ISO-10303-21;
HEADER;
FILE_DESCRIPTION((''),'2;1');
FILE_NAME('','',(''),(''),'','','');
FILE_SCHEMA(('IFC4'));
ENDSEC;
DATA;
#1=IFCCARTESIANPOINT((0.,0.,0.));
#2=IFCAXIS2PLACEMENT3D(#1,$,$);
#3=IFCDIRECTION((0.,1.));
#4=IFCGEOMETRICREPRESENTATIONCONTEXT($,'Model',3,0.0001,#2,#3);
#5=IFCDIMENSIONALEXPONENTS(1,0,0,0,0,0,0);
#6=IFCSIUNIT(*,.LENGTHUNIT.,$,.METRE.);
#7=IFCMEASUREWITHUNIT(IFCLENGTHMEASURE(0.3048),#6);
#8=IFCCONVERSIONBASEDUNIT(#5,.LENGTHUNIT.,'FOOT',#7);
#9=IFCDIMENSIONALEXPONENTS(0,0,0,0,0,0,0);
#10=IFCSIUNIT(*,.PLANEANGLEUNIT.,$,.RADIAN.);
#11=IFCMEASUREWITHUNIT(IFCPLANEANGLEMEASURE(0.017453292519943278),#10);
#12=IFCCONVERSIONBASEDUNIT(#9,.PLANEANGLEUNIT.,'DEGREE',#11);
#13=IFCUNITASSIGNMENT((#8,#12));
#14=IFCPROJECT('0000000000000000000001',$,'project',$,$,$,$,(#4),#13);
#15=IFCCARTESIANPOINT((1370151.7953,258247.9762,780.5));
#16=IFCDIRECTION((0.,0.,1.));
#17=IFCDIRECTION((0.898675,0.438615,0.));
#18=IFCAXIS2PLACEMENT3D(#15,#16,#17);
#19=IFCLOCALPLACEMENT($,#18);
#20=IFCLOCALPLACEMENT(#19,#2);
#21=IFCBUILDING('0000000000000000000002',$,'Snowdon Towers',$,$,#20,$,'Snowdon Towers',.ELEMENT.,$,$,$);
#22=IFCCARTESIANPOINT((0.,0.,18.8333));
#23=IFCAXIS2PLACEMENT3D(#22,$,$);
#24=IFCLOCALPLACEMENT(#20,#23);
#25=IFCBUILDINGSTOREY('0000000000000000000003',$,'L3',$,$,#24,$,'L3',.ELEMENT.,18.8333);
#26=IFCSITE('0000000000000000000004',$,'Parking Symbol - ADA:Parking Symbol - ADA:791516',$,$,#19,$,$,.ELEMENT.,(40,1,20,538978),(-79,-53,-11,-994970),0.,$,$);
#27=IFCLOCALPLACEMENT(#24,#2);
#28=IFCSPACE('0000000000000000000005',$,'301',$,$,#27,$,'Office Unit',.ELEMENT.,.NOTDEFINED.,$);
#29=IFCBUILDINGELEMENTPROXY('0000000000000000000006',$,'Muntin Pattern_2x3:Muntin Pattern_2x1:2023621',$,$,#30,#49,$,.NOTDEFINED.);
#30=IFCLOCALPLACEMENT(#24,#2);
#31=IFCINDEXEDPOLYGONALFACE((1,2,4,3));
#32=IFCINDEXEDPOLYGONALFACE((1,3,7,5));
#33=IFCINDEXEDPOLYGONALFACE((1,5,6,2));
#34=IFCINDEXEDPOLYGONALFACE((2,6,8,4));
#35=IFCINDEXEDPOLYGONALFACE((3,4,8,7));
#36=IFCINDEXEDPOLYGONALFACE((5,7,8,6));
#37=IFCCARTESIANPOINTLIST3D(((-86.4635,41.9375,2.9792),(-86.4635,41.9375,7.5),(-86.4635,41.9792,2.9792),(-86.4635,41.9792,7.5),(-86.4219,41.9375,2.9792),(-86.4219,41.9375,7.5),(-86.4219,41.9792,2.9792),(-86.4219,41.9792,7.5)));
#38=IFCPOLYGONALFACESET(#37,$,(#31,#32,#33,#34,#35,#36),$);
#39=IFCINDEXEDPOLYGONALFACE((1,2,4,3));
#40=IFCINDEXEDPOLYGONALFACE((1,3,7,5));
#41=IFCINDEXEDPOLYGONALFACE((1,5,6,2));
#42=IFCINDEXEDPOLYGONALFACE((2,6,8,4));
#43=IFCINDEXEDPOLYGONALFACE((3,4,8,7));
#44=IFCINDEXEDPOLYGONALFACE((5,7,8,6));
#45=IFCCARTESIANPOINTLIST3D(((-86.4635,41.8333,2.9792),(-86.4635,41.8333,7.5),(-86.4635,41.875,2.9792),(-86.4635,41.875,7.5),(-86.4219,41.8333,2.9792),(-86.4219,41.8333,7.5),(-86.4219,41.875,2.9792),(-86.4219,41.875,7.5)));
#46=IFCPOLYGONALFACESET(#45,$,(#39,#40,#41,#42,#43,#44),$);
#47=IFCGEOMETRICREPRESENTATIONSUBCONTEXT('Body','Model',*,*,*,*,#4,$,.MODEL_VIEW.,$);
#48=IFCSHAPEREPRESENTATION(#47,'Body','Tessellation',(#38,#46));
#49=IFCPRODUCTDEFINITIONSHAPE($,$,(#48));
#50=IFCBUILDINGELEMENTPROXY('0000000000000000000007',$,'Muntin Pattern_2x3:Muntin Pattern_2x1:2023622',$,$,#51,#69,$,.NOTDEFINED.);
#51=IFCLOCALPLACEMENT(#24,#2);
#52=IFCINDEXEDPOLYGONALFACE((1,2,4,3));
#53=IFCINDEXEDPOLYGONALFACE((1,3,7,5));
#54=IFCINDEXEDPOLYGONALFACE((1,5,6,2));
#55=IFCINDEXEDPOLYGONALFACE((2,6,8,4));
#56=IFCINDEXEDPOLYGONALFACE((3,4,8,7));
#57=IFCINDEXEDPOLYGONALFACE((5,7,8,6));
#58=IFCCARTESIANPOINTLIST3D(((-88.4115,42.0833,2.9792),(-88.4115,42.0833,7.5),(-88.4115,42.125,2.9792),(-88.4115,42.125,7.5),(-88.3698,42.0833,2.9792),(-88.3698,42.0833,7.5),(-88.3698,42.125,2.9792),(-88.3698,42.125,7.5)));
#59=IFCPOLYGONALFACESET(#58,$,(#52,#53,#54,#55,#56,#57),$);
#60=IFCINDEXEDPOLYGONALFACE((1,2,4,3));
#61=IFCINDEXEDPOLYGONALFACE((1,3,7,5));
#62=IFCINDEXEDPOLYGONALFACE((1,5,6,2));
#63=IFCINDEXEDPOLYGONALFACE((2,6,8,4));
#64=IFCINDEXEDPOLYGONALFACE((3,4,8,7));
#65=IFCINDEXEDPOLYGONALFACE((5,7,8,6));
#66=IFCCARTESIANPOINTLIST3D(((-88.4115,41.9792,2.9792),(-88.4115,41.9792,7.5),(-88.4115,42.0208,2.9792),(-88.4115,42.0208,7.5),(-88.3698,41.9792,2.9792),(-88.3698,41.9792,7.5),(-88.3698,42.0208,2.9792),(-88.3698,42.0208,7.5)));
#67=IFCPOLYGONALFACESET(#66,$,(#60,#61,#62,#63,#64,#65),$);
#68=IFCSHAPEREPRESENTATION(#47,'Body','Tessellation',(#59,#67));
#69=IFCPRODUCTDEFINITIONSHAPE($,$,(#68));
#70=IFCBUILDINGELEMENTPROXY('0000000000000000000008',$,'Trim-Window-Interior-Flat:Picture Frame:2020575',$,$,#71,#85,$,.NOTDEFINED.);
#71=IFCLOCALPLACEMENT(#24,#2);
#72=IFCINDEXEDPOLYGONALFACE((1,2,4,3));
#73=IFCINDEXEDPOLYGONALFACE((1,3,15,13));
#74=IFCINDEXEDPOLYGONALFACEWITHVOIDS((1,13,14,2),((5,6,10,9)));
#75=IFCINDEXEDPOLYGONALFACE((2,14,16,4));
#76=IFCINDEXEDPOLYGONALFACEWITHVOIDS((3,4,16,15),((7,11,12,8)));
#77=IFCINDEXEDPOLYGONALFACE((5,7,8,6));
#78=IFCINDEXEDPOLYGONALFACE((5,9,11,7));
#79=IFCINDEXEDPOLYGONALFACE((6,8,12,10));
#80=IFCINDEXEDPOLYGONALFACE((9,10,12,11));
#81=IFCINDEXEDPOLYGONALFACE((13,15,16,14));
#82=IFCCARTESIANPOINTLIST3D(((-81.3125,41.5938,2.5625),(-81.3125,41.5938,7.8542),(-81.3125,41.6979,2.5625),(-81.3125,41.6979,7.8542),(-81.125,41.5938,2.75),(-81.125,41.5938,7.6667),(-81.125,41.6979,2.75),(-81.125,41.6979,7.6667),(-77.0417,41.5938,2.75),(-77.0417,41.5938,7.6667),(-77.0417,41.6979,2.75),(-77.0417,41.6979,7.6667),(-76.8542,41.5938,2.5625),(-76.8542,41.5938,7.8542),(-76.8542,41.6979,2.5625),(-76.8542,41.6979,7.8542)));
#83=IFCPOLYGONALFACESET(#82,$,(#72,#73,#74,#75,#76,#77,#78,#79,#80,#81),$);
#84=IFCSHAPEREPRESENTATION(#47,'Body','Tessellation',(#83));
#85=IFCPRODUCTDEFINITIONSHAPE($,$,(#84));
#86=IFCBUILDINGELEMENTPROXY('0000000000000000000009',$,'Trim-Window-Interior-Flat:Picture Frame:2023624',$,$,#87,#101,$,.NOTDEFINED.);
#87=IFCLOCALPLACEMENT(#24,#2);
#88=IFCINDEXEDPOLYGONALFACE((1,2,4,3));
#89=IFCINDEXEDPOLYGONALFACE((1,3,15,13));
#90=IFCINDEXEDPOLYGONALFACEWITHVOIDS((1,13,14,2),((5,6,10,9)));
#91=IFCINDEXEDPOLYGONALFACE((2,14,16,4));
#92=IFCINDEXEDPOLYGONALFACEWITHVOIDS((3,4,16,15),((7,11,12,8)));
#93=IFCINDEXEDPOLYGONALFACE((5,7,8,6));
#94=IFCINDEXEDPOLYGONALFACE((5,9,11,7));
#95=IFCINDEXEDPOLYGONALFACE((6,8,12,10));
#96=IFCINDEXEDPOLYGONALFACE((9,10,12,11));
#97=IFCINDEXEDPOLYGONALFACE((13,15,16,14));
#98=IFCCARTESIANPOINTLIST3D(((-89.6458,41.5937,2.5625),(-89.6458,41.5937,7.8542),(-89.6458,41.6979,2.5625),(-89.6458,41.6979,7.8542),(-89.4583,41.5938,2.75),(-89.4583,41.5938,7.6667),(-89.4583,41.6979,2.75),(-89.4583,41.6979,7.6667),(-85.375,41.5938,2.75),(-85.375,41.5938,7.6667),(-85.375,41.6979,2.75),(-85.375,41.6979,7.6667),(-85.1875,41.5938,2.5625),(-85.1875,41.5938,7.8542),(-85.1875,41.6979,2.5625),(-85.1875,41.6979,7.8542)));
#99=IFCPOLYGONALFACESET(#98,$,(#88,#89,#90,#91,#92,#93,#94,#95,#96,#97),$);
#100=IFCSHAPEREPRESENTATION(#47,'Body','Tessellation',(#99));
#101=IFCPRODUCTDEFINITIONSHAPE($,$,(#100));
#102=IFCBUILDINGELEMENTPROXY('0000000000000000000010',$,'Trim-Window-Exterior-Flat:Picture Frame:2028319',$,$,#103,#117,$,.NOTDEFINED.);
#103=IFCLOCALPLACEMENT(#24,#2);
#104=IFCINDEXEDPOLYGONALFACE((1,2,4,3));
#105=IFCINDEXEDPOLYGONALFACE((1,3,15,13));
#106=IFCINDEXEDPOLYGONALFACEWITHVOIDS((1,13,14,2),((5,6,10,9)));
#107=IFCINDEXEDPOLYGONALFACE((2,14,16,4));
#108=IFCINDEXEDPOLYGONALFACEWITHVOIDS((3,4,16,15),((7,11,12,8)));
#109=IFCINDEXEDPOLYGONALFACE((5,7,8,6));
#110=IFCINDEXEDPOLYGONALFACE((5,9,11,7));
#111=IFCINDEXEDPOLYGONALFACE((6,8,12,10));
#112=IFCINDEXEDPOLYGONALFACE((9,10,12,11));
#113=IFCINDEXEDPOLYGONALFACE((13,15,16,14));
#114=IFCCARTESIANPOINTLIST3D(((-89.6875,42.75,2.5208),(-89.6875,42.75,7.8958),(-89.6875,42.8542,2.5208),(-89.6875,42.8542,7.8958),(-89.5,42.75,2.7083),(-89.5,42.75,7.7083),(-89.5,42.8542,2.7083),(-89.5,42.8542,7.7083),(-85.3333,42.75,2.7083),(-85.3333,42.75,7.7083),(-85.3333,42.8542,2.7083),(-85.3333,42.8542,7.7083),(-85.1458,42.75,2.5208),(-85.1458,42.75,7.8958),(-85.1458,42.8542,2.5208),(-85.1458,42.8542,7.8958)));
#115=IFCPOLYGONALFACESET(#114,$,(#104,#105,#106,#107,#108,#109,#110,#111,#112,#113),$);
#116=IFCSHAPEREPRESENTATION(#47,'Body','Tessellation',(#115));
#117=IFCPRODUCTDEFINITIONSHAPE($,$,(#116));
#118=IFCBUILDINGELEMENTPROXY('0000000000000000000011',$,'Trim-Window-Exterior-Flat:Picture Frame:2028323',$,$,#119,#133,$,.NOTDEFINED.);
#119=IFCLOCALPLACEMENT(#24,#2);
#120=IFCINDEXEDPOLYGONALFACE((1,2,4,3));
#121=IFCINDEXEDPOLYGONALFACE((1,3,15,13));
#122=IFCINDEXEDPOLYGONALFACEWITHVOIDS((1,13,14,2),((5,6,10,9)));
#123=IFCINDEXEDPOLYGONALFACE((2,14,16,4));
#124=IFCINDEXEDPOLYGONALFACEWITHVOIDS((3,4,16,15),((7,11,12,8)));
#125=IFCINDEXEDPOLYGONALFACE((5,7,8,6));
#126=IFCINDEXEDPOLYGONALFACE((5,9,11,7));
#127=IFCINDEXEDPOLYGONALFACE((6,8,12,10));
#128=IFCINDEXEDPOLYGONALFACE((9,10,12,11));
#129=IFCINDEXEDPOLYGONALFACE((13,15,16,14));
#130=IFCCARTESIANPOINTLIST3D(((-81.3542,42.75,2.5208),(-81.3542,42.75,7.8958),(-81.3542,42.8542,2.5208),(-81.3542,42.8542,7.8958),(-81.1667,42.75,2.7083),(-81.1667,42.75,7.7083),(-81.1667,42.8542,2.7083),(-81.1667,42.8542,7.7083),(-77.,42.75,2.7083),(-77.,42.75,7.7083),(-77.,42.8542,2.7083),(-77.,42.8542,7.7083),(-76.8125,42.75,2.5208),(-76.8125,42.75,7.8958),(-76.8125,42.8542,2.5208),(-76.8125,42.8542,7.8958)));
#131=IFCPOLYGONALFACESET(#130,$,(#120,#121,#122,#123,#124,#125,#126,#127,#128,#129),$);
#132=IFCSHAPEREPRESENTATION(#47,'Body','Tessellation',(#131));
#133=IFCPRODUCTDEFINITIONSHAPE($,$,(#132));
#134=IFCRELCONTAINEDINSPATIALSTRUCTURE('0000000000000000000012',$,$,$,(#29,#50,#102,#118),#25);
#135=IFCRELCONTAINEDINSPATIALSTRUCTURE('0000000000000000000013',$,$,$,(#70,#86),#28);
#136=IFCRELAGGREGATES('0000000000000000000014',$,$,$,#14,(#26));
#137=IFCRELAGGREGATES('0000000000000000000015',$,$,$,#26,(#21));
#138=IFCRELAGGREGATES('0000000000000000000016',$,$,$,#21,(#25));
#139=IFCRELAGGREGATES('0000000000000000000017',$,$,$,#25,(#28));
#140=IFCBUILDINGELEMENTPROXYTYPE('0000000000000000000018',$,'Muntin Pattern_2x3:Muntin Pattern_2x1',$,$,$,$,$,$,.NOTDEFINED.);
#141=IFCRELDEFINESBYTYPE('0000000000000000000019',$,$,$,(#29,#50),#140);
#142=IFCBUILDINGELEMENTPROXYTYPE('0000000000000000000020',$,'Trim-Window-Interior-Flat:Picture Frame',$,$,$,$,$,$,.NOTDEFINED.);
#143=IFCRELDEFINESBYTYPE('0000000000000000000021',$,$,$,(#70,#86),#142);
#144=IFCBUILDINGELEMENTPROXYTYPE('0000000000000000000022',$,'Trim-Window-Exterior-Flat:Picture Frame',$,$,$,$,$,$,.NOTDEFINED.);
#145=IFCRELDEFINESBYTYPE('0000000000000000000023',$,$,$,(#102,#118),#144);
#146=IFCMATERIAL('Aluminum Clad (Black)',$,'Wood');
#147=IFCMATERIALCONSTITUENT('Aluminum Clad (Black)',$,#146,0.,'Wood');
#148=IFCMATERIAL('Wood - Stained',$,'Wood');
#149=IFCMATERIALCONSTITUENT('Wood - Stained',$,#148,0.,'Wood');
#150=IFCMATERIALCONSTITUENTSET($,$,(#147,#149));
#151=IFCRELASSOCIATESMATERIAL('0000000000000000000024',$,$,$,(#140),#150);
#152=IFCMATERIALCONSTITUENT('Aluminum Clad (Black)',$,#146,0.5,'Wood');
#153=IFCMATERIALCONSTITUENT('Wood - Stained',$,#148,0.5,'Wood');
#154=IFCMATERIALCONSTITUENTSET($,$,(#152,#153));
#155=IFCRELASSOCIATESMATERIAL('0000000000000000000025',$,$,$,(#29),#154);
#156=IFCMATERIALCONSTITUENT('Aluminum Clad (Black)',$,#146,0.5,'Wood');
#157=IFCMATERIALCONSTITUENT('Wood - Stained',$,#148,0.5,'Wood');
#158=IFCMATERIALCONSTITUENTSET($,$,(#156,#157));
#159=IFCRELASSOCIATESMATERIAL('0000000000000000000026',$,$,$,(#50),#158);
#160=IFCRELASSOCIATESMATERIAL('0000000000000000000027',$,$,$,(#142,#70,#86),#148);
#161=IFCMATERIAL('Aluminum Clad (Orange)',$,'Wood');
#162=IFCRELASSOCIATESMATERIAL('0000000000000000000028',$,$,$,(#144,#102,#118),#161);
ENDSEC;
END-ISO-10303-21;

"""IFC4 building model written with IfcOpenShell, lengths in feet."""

from ifc_helpers import new_model, entity, si_unit, converted_unit, direction, frame, origin, place, context, subcontext, project, spatial, indexed_curve, outline, extrude, source, transform, mapped, material, constituent, constituent_set, type_object, type_shapes, element, save


model = new_model("IFC4")

# Units and contexts
model_context = context("Model", 3, precision=0.0001, world=origin(), true_north=direction((0.0, 1.0)))
body_context = subcontext(model_context, "Body", "Model", "MODEL_VIEW")
ifc_project = project(units=[converted_unit("LENGTHUNIT", "FOOT", entity("IfcLengthMeasure", 0.3048), si_unit("LENGTHUNIT", "METRE"), dimensions=[1, 0, 0, 0, 0, 0, 0]), converted_unit("PLANEANGLEUNIT", "DEGREE", entity("IfcPlaneAngleMeasure", 0.017453292519943278), si_unit("PLANEANGLEUNIT", "RADIAN"), dimensions=[0, 0, 0, 0, 0, 0, 0])], contexts=[model_context])

# Site, building, storey
site_placement = place(None, frame((1370151.7953, 258247.9762, 780.5), z_axis=(0.0, 0.0, 1.0), x_axis=(0.898675, 0.438615, 0.0)))
site = spatial("IfcSite", under=ifc_project, at=site_placement, Name="Parking Symbol - ADA:Parking Symbol - ADA:791516", CompositionType="ELEMENT", RefLatitude=(40, 1, 20, 538978), RefLongitude=(-79, -53, -11, -994970), RefElevation=0.0)
building_placement = place(site_placement, origin())
building = spatial("IfcBuilding", under=site, at=building_placement, Name="Snowdon Towers", LongName="Snowdon Towers", CompositionType="ELEMENT")
storey_placement = place(building_placement, frame((0.0, 0.0, 18.8333)))
storey = spatial("IfcBuildingStorey", under=building, at=storey_placement, Name="L3", LongName="L3", CompositionType="ELEMENT", Elevation=18.8333)

# Shared definitions
ifc_material_1 = material(Name="Aluminum Clad (Orange)", Category="Wood")
ifc_material_2 = material(Name="Aluminum Clad (Black)", Category="Wood")

# Building element proxies
ifc_material_3 = material(Name="Wood - Stained", Category="Wood")
ifc_constituent_1 = constituent(ifc_material_2, Name="Aluminum Clad (Black)", Category="Wood", fraction=0.0)
ifc_constituent_2 = constituent(ifc_material_3, Name="Wood - Stained", Category="Wood", fraction=0.0)
ifc_constituent_set_1 = constituent_set(constituents=[ifc_constituent_1, ifc_constituent_2])
building_element_proxy_type_1 = type_object("IfcBuildingElementProxyType", Name="Muntin Pattern_2x3:Muntin Pattern_2x1", PredefinedType="NOTDEFINED", material=ifc_constituent_set_1)
shared_shape_1 = source(origin(), body_context, "Body", "SweptSolid", [
    extrude(outline(indexed_curve([(-0.0208, -0.0208), (0.0208, -0.0208), (0.0208, 0.0208), (-0.0208, 0.0208), (-0.0208, -0.0208)], self_intersect=False)), frame((0.0, 0.0521, 0.0), z_axis=(0.0, 0.0, 1.0), x_axis=(0.0, -1.0, 0.0)), (0.0, 0.0, 1.0), 4.5208),
    extrude(outline(indexed_curve([(-0.0208, -0.0208), (0.0208, -0.0208), (0.0208, 0.0208), (-0.0208, 0.0208), (-0.0208, -0.0208)], self_intersect=False)), frame((0.0, -0.0521, 0.0), z_axis=(0.0, 0.0, 1.0), x_axis=(0.0, -1.0, 0.0)), (0.0, 0.0, 1.0), 4.5208),
])
type_shapes(building_element_proxy_type_1, [shared_shape_1])
ifc_constituent_3 = constituent(ifc_material_2, Name="Aluminum Clad (Black)", Category="Wood", fraction=0.5)
ifc_constituent_4 = constituent(ifc_material_3, Name="Wood - Stained", Category="Wood", fraction=0.5)
ifc_constituent_set_2 = constituent_set(constituents=[ifc_constituent_3, ifc_constituent_4])
proxy_1_placement = place(storey_placement, frame((-86.4427, 41.9063, 2.9792)))
element("IfcBuildingElementProxy", 1, at=proxy_1_placement, inside=storey, type_object=building_element_proxy_type_1, material=ifc_constituent_set_2, Name="Muntin Pattern_2x3:Muntin Pattern_2x1:2023621", PredefinedType="NOTDEFINED", context=body_context, shape_type="MappedRepresentation", body=[
    mapped(shared_shape_1, transform((0.0, 0.0, 0.0), scale=1.0)),
])
ifc_constituent_5 = constituent(ifc_material_2, Name="Aluminum Clad (Black)", Category="Wood", fraction=0.5)
ifc_constituent_6 = constituent(ifc_material_3, Name="Wood - Stained", Category="Wood", fraction=0.5)
ifc_constituent_set_3 = constituent_set(constituents=[ifc_constituent_5, ifc_constituent_6])
proxy_2_placement = place(storey_placement, frame((-88.3906, 42.0521, 2.9792)))
element("IfcBuildingElementProxy", 2, at=proxy_2_placement, inside=storey, type_object=building_element_proxy_type_1, material=ifc_constituent_set_3, Name="Muntin Pattern_2x3:Muntin Pattern_2x1:2023622", PredefinedType="NOTDEFINED", context=body_context, shape_type="MappedRepresentation", body=[
    mapped(shared_shape_1, transform((0.0, 0.0, 0.0), scale=1.0)),
])

# Shared definitions
space_placement = place(storey_placement, origin())
space = spatial("IfcSpace", under=storey, at=space_placement, Name="301", LongName="Office Unit", CompositionType="ELEMENT", PredefinedType="NOTDEFINED")

# Building element proxies
building_element_proxy_type_2 = type_object("IfcBuildingElementProxyType", Name="Trim-Window-Interior-Flat:Picture Frame", PredefinedType="NOTDEFINED", material=ifc_material_3)
shared_shape_2 = source(origin(), body_context, "Body", "SweptSolid", [
    extrude(outline(indexed_curve([(-2.2292, -2.6458), (2.2292, -2.6458), (2.2292, 2.6458), (-2.2292, 2.6458), (-2.2292, -2.6458)], self_intersect=False), holes=[indexed_curve([(-2.0417, -2.4583), (-2.0417, 2.4583), (2.0417, 2.4583), (2.0417, -2.4583), (-2.0417, -2.4583)], self_intersect=False)]), frame((0.0, -2.5, 0.0), z_axis=(0.0, 0.0, 1.0), x_axis=(-1.0, 0.0, 0.0)), (0.0, 0.0, 1.0), 0.1042),
])
type_shapes(building_element_proxy_type_2, [shared_shape_2])
for number, where, z_axis, x_axis, name in (
    (3, (-79.0833, 41.6979, 7.7083), (0.0, -1.0, 0.0), (1.0, 0.0, 0.0), "Trim-Window-Interior-Flat:Picture Frame:2020575"),
    (4, (-87.4167, 41.6979, 7.7083), (0.0, -1.0, 0.0), (1.0, 0.0, 0.0), "Trim-Window-Interior-Flat:Picture Frame:2023624"),
):
    element("IfcBuildingElementProxy", number, at=place(space_placement, frame(where, z_axis=z_axis, x_axis=x_axis)), inside=space, type_object=building_element_proxy_type_2, material=ifc_material_3, Name=name, PredefinedType="NOTDEFINED", context=body_context, shape_type="MappedRepresentation", body=[
        mapped(shared_shape_2, transform((0.0, 0.0, 0.0), scale=1.0)),
    ])
building_element_proxy_type_3 = type_object("IfcBuildingElementProxyType", Name="Trim-Window-Exterior-Flat:Picture Frame", PredefinedType="NOTDEFINED", material=ifc_material_1)
shared_shape_3 = source(origin(), body_context, "Body", "SweptSolid", [
    extrude(outline(indexed_curve([(-2.2708, -2.6875), (2.2708, -2.6875), (2.2708, 2.6875), (-2.2708, 2.6875), (-2.2708, -2.6875)], self_intersect=False), holes=[indexed_curve([(-2.0833, -2.5), (-2.0833, 2.5), (2.0833, 2.5), (2.0833, -2.5), (-2.0833, -2.5)], self_intersect=False)]), frame((0.0, -2.5, 0.0), z_axis=(0.0, 0.0, 1.0), x_axis=(-1.0, 0.0, 0.0)), (0.0, 0.0, 1.0), 0.1042),
])
type_shapes(building_element_proxy_type_3, [shared_shape_3])
for number, where, z_axis, x_axis, name in (
    (5, (-87.4167, 42.75, 7.7083), (0.0, 1.0, 0.0), (-1.0, 0.0, 0.0), "Trim-Window-Exterior-Flat:Picture Frame:2028319"),
    (6, (-79.0833, 42.75, 7.7083), (0.0, 1.0, 0.0), (-1.0, 0.0, 0.0), "Trim-Window-Exterior-Flat:Picture Frame:2028323"),
):
    element("IfcBuildingElementProxy", number, at=place(storey_placement, frame(where, z_axis=z_axis, x_axis=x_axis)), inside=storey, type_object=building_element_proxy_type_3, material=ifc_material_1, Name=name, PredefinedType="NOTDEFINED", context=body_context, shape_type="MappedRepresentation", body=[
        mapped(shared_shape_3, transform((0.0, 0.0, 0.0), scale=1.0)),
    ])

save(model, "model.ifc")
